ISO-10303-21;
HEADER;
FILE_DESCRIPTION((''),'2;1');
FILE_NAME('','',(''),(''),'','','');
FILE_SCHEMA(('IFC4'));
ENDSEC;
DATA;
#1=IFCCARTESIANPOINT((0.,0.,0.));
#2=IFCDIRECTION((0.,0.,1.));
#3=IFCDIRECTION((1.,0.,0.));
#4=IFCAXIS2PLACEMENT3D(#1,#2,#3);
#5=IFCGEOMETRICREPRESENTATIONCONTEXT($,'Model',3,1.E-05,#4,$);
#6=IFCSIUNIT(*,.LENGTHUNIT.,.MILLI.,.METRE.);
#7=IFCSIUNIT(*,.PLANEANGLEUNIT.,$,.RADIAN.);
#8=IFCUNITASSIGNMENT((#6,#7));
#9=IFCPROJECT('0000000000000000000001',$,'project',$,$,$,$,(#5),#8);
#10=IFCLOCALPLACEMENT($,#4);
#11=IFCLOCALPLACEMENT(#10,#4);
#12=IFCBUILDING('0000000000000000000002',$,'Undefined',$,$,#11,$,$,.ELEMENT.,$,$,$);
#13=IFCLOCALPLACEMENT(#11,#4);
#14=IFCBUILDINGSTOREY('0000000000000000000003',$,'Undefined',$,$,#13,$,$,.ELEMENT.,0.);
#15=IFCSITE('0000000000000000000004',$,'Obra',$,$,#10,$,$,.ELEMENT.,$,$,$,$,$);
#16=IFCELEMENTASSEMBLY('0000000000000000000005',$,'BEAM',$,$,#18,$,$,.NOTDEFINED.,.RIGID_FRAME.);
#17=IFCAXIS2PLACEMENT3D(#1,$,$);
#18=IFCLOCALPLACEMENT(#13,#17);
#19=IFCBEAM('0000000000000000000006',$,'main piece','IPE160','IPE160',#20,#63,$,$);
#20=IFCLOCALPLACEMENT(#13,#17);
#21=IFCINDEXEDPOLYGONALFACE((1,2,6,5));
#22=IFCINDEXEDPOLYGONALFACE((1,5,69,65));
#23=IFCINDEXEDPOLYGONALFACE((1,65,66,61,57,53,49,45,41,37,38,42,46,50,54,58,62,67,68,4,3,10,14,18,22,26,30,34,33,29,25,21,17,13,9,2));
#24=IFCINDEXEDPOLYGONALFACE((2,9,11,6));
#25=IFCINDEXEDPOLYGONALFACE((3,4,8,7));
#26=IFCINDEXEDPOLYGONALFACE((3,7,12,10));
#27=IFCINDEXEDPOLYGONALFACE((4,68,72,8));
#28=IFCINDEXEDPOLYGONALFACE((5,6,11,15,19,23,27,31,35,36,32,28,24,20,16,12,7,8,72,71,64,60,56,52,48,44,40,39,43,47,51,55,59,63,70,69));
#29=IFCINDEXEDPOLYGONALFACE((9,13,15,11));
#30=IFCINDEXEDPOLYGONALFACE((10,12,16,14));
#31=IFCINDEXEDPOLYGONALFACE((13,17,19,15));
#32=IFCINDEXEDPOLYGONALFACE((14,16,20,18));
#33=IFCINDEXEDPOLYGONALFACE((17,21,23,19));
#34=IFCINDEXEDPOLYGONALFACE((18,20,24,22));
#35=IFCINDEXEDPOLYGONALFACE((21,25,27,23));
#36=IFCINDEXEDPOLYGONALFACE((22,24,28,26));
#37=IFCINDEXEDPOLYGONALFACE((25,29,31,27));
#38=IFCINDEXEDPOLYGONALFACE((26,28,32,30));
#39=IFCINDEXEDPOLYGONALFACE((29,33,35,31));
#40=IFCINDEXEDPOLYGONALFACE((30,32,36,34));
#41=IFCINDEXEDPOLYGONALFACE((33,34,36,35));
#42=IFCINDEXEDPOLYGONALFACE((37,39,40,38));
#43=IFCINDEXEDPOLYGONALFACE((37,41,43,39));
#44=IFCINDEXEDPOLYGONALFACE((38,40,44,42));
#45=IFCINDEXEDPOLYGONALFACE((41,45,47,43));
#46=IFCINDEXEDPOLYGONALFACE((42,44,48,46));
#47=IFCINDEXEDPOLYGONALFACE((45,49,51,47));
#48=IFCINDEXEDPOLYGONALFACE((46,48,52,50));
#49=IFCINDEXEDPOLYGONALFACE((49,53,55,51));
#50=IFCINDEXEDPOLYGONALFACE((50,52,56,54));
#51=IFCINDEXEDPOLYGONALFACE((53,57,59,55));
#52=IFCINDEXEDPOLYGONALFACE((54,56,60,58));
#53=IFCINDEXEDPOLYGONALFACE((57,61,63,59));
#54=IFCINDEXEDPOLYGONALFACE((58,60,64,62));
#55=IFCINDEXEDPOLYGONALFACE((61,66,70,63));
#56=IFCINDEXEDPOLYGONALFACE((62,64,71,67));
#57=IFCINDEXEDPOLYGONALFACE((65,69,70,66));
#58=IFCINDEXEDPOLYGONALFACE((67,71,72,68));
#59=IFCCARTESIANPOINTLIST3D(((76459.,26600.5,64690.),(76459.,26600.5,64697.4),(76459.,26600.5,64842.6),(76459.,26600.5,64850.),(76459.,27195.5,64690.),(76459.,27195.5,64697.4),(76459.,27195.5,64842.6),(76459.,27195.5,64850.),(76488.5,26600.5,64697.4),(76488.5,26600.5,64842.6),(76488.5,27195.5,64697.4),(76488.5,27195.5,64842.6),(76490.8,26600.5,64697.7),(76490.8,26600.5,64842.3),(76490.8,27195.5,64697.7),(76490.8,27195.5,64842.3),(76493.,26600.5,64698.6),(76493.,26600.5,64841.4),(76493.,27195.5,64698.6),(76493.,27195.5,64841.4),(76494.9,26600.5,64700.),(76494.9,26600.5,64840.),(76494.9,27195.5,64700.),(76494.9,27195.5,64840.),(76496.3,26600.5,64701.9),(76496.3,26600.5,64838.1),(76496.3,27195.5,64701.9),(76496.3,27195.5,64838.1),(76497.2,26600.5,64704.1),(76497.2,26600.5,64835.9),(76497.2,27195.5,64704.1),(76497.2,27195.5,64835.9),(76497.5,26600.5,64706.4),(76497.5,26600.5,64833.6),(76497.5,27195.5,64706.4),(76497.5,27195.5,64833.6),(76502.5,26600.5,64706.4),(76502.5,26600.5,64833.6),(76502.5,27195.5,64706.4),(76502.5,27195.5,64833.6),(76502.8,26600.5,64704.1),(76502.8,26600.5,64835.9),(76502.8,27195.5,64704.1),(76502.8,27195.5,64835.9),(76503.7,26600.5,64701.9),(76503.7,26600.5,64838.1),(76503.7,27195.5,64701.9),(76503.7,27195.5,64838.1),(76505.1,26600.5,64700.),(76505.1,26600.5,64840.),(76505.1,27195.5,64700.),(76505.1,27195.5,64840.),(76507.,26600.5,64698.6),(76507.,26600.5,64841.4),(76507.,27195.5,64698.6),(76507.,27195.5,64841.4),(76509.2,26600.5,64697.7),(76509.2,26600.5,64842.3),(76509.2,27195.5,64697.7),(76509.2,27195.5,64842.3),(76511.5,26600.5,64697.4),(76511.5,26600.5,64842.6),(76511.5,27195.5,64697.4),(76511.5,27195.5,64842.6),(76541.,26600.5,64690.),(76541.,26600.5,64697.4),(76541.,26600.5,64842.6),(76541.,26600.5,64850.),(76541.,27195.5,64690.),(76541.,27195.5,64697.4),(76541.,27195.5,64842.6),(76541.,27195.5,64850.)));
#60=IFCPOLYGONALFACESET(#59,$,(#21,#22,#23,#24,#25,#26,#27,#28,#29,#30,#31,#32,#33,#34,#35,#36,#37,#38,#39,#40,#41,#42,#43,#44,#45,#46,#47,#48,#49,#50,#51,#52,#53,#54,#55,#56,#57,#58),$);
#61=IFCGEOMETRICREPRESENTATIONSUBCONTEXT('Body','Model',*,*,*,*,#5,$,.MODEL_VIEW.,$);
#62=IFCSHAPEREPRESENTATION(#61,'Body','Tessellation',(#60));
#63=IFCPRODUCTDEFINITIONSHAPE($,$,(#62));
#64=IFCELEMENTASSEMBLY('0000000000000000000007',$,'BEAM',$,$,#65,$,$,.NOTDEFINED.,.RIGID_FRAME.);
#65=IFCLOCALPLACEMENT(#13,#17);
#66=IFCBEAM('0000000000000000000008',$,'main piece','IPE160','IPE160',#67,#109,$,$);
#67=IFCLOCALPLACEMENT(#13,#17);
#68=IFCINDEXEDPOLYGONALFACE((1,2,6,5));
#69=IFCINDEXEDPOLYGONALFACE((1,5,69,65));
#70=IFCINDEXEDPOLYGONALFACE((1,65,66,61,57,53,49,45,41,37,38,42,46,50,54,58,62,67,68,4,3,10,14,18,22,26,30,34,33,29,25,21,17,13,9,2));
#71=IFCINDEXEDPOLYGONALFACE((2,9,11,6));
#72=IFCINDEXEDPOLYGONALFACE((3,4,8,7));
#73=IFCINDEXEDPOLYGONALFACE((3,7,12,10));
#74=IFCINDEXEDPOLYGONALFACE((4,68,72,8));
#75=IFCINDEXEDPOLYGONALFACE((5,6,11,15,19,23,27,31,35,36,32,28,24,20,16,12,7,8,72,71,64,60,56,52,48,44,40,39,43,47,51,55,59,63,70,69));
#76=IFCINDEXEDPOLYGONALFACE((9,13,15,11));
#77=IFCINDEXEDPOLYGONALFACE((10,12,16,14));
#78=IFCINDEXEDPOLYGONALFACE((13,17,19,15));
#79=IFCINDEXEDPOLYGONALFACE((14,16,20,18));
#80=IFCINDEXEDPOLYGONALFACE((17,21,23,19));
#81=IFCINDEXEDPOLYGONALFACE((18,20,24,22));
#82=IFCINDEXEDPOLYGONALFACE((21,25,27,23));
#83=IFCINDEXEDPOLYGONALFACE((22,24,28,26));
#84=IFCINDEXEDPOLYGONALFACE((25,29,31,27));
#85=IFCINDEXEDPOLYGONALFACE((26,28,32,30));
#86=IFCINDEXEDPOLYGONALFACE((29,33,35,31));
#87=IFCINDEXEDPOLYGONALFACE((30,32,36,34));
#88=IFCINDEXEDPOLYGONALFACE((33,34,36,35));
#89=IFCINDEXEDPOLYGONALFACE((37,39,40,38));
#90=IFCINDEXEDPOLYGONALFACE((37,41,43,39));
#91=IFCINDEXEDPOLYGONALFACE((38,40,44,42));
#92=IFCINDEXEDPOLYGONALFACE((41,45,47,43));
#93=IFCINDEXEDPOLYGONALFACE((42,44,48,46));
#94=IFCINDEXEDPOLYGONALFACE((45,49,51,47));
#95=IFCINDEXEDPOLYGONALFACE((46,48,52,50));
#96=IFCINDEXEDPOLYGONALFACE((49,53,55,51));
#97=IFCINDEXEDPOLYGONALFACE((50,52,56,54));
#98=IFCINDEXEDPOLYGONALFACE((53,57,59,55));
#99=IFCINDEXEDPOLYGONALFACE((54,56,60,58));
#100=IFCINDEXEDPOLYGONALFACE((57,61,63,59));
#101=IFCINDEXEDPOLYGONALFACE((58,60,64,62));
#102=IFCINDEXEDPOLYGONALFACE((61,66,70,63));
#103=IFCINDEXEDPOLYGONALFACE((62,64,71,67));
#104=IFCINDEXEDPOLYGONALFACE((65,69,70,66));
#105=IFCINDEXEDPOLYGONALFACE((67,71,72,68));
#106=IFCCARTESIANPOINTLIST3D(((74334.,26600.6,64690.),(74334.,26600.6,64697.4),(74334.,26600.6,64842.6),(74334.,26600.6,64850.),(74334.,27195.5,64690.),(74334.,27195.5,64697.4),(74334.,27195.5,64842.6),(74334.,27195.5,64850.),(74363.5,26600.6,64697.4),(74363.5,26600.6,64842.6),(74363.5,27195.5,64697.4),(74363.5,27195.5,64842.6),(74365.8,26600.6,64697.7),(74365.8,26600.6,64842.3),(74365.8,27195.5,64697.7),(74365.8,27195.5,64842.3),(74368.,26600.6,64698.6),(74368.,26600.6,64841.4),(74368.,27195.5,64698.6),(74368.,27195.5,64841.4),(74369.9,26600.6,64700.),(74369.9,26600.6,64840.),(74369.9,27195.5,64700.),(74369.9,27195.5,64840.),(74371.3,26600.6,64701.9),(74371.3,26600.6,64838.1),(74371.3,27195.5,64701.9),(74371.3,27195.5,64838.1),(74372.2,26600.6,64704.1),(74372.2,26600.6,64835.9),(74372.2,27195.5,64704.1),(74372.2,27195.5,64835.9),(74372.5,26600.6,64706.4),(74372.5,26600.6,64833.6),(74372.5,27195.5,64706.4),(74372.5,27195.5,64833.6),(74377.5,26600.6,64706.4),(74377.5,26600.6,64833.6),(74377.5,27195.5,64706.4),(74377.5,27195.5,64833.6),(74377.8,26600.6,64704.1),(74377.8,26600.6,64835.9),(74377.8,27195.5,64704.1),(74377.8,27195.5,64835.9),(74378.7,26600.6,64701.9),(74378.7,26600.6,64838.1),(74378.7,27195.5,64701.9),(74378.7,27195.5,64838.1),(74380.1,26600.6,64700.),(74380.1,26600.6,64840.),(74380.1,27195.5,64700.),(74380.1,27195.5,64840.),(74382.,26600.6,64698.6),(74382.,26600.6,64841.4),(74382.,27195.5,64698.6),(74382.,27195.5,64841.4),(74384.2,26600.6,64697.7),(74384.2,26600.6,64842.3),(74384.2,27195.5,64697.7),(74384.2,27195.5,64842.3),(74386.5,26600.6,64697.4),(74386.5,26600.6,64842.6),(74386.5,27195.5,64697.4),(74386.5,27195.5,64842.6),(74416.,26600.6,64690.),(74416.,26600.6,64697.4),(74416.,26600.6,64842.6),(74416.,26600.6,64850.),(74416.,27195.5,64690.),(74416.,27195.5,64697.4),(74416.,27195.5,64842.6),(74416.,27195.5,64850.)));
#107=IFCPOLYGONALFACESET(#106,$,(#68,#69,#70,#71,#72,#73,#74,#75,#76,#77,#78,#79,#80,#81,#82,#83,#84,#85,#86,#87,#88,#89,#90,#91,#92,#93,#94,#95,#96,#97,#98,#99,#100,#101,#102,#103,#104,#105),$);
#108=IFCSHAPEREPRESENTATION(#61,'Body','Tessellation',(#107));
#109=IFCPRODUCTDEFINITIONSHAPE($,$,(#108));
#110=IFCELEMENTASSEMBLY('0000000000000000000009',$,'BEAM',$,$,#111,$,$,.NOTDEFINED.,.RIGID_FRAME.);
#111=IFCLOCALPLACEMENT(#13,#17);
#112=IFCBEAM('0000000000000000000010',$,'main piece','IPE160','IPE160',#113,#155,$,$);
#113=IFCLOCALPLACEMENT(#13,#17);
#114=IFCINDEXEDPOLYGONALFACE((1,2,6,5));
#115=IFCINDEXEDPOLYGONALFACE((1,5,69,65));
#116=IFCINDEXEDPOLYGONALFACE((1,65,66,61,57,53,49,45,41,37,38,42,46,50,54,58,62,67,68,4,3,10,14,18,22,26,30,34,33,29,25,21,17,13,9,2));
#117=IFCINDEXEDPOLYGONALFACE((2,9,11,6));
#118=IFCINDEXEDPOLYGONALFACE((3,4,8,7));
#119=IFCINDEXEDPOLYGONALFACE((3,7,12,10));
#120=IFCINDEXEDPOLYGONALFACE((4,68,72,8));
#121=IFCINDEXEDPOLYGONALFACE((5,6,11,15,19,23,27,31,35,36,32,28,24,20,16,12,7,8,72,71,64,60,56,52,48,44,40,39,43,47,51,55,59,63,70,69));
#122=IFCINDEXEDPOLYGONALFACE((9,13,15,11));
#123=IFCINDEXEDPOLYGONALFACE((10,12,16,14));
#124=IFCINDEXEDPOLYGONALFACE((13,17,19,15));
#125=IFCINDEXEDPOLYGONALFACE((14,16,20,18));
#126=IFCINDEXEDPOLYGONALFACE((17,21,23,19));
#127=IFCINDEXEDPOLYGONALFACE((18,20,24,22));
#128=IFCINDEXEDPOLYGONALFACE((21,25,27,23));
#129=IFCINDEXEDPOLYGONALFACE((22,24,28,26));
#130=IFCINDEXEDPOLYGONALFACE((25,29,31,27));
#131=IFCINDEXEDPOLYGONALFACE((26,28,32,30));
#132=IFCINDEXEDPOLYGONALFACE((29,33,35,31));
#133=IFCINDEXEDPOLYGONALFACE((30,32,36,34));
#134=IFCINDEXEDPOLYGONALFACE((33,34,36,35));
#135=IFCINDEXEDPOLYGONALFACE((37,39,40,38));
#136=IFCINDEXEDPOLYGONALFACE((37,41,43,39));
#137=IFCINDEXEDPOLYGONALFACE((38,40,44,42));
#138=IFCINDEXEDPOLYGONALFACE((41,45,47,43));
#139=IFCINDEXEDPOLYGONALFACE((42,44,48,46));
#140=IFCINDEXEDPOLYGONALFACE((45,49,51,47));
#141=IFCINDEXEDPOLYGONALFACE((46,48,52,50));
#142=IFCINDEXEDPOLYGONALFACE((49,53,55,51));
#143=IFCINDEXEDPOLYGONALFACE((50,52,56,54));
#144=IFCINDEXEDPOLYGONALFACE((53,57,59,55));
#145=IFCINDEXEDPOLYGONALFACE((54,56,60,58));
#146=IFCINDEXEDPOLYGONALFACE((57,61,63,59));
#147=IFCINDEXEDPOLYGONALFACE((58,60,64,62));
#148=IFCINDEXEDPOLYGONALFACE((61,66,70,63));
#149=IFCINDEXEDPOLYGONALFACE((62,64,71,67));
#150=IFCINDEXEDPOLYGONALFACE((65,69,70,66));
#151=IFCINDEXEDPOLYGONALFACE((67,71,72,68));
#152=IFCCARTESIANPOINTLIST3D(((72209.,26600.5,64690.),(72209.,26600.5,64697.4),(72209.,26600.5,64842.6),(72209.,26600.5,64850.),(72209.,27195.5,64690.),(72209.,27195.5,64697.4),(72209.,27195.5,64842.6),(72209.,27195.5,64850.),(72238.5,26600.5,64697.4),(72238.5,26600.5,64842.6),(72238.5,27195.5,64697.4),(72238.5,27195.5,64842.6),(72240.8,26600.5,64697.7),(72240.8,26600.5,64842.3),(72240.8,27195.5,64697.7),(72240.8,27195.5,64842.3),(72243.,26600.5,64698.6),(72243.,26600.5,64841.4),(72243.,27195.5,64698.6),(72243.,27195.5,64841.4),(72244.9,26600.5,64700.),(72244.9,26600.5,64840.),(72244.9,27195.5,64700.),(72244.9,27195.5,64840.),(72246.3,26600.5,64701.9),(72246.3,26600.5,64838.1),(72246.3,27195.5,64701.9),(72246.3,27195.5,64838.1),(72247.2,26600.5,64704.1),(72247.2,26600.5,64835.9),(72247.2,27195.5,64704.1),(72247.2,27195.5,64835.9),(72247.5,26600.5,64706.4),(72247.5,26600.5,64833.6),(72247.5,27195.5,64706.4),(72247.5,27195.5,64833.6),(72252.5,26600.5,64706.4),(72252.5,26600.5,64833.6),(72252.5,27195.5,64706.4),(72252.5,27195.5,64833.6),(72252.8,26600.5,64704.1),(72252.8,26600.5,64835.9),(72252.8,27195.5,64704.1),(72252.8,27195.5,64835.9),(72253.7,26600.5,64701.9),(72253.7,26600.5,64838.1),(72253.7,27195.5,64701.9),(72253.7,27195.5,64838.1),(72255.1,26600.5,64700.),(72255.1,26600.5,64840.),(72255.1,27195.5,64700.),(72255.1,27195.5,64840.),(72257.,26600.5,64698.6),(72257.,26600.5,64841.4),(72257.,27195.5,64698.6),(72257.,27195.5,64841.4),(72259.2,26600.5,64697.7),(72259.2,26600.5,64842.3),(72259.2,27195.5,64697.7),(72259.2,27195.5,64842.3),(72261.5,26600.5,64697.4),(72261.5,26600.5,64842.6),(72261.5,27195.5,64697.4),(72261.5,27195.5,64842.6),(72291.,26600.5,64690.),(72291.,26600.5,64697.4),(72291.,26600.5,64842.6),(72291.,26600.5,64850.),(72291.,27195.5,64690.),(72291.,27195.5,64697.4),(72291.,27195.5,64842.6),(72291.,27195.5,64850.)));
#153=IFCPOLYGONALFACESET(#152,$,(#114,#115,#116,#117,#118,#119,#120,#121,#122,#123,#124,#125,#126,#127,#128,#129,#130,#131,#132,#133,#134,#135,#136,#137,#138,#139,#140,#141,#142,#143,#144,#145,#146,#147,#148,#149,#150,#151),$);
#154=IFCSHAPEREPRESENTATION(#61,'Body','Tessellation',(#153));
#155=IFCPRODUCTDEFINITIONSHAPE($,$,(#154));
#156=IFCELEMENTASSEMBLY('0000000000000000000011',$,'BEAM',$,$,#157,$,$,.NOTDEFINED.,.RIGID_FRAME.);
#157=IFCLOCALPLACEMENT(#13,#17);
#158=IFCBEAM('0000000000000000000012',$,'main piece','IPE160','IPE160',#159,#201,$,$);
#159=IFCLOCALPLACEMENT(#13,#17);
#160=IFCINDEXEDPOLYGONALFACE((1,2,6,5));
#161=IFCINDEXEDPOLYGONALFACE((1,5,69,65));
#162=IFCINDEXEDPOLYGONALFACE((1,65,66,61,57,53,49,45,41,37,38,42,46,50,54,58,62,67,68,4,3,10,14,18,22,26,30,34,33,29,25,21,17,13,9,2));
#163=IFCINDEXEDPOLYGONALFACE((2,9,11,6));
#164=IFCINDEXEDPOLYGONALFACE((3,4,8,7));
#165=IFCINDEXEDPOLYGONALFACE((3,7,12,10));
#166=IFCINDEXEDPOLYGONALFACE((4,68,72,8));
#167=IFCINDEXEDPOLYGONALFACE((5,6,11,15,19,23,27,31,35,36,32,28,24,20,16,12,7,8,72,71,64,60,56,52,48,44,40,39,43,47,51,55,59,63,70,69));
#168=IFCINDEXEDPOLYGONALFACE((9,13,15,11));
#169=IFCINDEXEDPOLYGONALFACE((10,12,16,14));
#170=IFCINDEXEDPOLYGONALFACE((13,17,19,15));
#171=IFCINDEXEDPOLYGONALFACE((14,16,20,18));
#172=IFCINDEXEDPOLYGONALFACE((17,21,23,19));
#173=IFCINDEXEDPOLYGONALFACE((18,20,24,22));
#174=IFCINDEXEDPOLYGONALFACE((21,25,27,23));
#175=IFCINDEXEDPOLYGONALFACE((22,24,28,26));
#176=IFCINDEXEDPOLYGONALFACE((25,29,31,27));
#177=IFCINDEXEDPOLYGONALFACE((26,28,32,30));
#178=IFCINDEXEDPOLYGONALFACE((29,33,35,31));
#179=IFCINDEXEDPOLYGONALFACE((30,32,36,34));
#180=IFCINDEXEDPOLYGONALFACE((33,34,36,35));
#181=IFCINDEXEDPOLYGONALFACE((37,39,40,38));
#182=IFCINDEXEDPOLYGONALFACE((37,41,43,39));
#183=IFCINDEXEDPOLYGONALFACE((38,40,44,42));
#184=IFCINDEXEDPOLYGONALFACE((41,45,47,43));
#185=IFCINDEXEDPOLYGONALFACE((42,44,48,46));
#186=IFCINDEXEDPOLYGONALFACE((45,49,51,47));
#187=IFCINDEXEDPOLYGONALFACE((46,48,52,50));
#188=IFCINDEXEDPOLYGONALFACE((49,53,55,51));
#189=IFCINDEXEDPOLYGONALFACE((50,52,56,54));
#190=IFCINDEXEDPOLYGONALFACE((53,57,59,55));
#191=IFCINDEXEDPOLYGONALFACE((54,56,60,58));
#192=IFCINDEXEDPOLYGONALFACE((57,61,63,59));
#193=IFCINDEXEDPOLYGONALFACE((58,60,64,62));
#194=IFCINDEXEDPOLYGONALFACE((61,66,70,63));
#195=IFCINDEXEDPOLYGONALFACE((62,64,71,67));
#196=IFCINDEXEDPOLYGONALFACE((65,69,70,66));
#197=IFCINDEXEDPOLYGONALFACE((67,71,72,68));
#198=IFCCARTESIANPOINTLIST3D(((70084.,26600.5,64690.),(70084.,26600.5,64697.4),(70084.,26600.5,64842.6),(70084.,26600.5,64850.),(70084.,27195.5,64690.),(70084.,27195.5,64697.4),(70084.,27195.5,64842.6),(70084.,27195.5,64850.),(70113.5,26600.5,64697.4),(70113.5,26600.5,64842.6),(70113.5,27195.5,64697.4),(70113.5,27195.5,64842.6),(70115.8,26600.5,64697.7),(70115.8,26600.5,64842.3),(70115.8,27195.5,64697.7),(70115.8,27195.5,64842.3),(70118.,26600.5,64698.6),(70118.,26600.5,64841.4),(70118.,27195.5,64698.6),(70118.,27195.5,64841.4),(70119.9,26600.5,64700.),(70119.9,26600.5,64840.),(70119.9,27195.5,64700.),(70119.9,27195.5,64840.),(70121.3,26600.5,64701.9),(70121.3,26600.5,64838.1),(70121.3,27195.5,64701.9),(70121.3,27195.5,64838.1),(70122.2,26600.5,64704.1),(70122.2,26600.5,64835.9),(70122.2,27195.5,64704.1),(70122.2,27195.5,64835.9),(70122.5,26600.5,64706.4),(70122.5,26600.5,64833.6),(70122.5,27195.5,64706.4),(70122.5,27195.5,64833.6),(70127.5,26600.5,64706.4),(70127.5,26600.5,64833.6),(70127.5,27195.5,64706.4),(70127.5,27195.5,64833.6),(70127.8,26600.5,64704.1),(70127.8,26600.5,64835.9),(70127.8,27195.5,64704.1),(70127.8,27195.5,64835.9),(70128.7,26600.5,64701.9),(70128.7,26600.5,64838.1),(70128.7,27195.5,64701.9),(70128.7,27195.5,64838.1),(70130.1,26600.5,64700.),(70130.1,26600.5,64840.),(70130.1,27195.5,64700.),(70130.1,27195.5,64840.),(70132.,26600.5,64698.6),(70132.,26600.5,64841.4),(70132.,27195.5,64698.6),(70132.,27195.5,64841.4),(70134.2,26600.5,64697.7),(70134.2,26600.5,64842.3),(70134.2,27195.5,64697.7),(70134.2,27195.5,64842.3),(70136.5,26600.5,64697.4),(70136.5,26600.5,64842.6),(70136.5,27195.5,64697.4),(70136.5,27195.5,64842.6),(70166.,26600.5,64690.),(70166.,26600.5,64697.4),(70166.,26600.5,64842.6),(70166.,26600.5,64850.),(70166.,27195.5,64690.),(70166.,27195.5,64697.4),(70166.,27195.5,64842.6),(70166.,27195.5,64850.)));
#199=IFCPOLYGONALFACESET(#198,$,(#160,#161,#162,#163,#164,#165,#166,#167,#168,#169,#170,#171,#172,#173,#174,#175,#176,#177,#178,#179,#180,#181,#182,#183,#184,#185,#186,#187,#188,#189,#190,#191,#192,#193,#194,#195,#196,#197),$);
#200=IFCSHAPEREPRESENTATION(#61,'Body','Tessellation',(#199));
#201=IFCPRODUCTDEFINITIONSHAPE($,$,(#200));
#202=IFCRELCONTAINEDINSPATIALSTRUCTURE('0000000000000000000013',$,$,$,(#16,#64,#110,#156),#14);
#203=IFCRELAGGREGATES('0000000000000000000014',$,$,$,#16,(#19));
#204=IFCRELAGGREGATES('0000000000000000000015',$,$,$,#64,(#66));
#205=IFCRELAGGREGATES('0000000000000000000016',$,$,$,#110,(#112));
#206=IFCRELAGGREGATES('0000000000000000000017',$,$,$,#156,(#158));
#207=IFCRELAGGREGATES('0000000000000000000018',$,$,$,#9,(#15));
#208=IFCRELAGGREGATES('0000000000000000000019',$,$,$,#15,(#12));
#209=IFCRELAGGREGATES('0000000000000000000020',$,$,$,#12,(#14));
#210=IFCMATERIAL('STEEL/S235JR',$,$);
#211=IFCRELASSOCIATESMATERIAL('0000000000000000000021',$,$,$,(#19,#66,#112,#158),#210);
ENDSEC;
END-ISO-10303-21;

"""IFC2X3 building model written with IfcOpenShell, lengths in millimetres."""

from ifc_helpers import new_model, si_unit, frame, origin_with_axes, origin_2d_with_axis, place, context, subcontext, project, spatial, i_section, extrude, material, element, aggregate, save


model = new_model("IFC2X3")

# Units and contexts
model_context = context("Model", 3, precision=1e-05, world=origin_with_axes())
body_context = subcontext(model_context, "Body", "Model", "MODEL_VIEW")
ifc_project = project(units=[si_unit("LENGTHUNIT", "METRE", prefix="MILLI"), si_unit("PLANEANGLEUNIT", "RADIAN")], contexts=[model_context])

# Site, building, storey
site_placement = place(None, origin_with_axes())
site = spatial("IfcSite", under=ifc_project, at=site_placement, Name="Obra", CompositionType="ELEMENT")
building_placement = place(site_placement, origin_with_axes())
building = spatial("IfcBuilding", under=site, at=building_placement, Name="Undefined", CompositionType="ELEMENT")
storey_placement = place(building_placement, origin_with_axes())
storey = spatial("IfcBuildingStorey", under=building, at=storey_placement, Name="Undefined", CompositionType="ELEMENT", Elevation=0.0)

# Element assemblies, beams
ifc_material_1 = material(Name="STEEL/S235JR")
assembly_1_placement = place(storey_placement, origin_with_axes())
assembly_1 = element("IfcElementAssembly", 1, at=assembly_1_placement, inside=storey, Name="BEAM", AssemblyPlace="NOTDEFINED", PredefinedType="RIGID_FRAME")
beam_1_placement = place(assembly_1_placement, frame((76500.0, 26600.5, 64770.0), z_axis=(0.0, 0.0, 1.0), x_axis=(0.0, 1.0, 0.0)))
beam_1 = element("IfcBeam", 2, at=beam_1_placement, material=ifc_material_1, Name="main piece", Description="IPE160", ObjectType="IPE160", context=body_context, shape_type="SweptSolid", body=[
    extrude(i_section(OverallWidth=82.0, OverallDepth=160.0, WebThickness=5.0, FlangeThickness=7.4, FilletRadius=9.0, at=origin_2d_with_axis()), frame((595.0, 0.0, 0.0), z_axis=(-1.0, 0.0, 0.0), x_axis=(0.0, -1.0, 0.0)), (0.0, 0.0, 1.0), 595.0),
])
aggregate(assembly_1, [beam_1])
assembly_2_placement = place(storey_placement, origin_with_axes())
assembly_2 = element("IfcElementAssembly", 3, at=assembly_2_placement, inside=storey, Name="BEAM", AssemblyPlace="NOTDEFINED", PredefinedType="RIGID_FRAME")
beam_2_placement = place(assembly_2_placement, frame((74375.0, 26600.6, 64770.0), z_axis=(0.0, 0.0, 1.0), x_axis=(0.0, 1.0, 0.0)))
beam_2 = element("IfcBeam", 4, at=beam_2_placement, material=ifc_material_1, Name="main piece", Description="IPE160", ObjectType="IPE160", context=body_context, shape_type="SweptSolid", body=[
    extrude(i_section(OverallWidth=82.0, OverallDepth=160.0, WebThickness=5.0, FlangeThickness=7.4, FilletRadius=9.0, at=origin_2d_with_axis()), frame((594.9, 0.0, 0.0), z_axis=(-1.0, 0.0, 0.0), x_axis=(0.0, -1.0, 0.0)), (0.0, 0.0, 1.0), 594.9),
])
aggregate(assembly_2, [beam_2])
assembly_3_placement = place(storey_placement, origin_with_axes())
assembly_3 = element("IfcElementAssembly", 5, at=assembly_3_placement, inside=storey, Name="BEAM", AssemblyPlace="NOTDEFINED", PredefinedType="RIGID_FRAME")
beam_3_placement = place(assembly_3_placement, frame((72250.0, 26600.5, 64770.0), z_axis=(0.0, 0.0, 1.0), x_axis=(0.0, 1.0, 0.0)))
beam_3 = element("IfcBeam", 6, at=beam_3_placement, material=ifc_material_1, Name="main piece", Description="IPE160", ObjectType="IPE160", context=body_context, shape_type="SweptSolid", body=[
    extrude(i_section(OverallWidth=82.0, OverallDepth=160.0, WebThickness=5.0, FlangeThickness=7.4, FilletRadius=9.0, at=origin_2d_with_axis()), frame((595.1, 0.0, 0.0), z_axis=(-1.0, 0.0, 0.0), x_axis=(0.0, -1.0, 0.0)), (0.0, 0.0, 1.0), 595.0),
])
aggregate(assembly_3, [beam_3])
assembly_4_placement = place(storey_placement, origin_with_axes())
assembly_4 = element("IfcElementAssembly", 7, at=assembly_4_placement, inside=storey, Name="BEAM", AssemblyPlace="NOTDEFINED", PredefinedType="RIGID_FRAME")
beam_4_placement = place(assembly_4_placement, frame((70125.0, 26600.5, 64770.0), z_axis=(0.0, 0.0, 1.0), x_axis=(0.0, 1.0, 0.0)))
beam_4 = element("IfcBeam", 8, at=beam_4_placement, material=ifc_material_1, Name="main piece", Description="IPE160", ObjectType="IPE160", context=body_context, shape_type="SweptSolid", body=[
    extrude(i_section(OverallWidth=82.0, OverallDepth=160.0, WebThickness=5.0, FlangeThickness=7.4, FilletRadius=9.0, at=origin_2d_with_axis()), frame((595.1, 0.0, 0.0), z_axis=(-1.0, 0.0, 0.0), x_axis=(0.0, -1.0, 0.0)), (0.0, 0.0, 1.0), 595.0),
])
aggregate(assembly_4, [beam_4])

save(model, "model.ifc")
